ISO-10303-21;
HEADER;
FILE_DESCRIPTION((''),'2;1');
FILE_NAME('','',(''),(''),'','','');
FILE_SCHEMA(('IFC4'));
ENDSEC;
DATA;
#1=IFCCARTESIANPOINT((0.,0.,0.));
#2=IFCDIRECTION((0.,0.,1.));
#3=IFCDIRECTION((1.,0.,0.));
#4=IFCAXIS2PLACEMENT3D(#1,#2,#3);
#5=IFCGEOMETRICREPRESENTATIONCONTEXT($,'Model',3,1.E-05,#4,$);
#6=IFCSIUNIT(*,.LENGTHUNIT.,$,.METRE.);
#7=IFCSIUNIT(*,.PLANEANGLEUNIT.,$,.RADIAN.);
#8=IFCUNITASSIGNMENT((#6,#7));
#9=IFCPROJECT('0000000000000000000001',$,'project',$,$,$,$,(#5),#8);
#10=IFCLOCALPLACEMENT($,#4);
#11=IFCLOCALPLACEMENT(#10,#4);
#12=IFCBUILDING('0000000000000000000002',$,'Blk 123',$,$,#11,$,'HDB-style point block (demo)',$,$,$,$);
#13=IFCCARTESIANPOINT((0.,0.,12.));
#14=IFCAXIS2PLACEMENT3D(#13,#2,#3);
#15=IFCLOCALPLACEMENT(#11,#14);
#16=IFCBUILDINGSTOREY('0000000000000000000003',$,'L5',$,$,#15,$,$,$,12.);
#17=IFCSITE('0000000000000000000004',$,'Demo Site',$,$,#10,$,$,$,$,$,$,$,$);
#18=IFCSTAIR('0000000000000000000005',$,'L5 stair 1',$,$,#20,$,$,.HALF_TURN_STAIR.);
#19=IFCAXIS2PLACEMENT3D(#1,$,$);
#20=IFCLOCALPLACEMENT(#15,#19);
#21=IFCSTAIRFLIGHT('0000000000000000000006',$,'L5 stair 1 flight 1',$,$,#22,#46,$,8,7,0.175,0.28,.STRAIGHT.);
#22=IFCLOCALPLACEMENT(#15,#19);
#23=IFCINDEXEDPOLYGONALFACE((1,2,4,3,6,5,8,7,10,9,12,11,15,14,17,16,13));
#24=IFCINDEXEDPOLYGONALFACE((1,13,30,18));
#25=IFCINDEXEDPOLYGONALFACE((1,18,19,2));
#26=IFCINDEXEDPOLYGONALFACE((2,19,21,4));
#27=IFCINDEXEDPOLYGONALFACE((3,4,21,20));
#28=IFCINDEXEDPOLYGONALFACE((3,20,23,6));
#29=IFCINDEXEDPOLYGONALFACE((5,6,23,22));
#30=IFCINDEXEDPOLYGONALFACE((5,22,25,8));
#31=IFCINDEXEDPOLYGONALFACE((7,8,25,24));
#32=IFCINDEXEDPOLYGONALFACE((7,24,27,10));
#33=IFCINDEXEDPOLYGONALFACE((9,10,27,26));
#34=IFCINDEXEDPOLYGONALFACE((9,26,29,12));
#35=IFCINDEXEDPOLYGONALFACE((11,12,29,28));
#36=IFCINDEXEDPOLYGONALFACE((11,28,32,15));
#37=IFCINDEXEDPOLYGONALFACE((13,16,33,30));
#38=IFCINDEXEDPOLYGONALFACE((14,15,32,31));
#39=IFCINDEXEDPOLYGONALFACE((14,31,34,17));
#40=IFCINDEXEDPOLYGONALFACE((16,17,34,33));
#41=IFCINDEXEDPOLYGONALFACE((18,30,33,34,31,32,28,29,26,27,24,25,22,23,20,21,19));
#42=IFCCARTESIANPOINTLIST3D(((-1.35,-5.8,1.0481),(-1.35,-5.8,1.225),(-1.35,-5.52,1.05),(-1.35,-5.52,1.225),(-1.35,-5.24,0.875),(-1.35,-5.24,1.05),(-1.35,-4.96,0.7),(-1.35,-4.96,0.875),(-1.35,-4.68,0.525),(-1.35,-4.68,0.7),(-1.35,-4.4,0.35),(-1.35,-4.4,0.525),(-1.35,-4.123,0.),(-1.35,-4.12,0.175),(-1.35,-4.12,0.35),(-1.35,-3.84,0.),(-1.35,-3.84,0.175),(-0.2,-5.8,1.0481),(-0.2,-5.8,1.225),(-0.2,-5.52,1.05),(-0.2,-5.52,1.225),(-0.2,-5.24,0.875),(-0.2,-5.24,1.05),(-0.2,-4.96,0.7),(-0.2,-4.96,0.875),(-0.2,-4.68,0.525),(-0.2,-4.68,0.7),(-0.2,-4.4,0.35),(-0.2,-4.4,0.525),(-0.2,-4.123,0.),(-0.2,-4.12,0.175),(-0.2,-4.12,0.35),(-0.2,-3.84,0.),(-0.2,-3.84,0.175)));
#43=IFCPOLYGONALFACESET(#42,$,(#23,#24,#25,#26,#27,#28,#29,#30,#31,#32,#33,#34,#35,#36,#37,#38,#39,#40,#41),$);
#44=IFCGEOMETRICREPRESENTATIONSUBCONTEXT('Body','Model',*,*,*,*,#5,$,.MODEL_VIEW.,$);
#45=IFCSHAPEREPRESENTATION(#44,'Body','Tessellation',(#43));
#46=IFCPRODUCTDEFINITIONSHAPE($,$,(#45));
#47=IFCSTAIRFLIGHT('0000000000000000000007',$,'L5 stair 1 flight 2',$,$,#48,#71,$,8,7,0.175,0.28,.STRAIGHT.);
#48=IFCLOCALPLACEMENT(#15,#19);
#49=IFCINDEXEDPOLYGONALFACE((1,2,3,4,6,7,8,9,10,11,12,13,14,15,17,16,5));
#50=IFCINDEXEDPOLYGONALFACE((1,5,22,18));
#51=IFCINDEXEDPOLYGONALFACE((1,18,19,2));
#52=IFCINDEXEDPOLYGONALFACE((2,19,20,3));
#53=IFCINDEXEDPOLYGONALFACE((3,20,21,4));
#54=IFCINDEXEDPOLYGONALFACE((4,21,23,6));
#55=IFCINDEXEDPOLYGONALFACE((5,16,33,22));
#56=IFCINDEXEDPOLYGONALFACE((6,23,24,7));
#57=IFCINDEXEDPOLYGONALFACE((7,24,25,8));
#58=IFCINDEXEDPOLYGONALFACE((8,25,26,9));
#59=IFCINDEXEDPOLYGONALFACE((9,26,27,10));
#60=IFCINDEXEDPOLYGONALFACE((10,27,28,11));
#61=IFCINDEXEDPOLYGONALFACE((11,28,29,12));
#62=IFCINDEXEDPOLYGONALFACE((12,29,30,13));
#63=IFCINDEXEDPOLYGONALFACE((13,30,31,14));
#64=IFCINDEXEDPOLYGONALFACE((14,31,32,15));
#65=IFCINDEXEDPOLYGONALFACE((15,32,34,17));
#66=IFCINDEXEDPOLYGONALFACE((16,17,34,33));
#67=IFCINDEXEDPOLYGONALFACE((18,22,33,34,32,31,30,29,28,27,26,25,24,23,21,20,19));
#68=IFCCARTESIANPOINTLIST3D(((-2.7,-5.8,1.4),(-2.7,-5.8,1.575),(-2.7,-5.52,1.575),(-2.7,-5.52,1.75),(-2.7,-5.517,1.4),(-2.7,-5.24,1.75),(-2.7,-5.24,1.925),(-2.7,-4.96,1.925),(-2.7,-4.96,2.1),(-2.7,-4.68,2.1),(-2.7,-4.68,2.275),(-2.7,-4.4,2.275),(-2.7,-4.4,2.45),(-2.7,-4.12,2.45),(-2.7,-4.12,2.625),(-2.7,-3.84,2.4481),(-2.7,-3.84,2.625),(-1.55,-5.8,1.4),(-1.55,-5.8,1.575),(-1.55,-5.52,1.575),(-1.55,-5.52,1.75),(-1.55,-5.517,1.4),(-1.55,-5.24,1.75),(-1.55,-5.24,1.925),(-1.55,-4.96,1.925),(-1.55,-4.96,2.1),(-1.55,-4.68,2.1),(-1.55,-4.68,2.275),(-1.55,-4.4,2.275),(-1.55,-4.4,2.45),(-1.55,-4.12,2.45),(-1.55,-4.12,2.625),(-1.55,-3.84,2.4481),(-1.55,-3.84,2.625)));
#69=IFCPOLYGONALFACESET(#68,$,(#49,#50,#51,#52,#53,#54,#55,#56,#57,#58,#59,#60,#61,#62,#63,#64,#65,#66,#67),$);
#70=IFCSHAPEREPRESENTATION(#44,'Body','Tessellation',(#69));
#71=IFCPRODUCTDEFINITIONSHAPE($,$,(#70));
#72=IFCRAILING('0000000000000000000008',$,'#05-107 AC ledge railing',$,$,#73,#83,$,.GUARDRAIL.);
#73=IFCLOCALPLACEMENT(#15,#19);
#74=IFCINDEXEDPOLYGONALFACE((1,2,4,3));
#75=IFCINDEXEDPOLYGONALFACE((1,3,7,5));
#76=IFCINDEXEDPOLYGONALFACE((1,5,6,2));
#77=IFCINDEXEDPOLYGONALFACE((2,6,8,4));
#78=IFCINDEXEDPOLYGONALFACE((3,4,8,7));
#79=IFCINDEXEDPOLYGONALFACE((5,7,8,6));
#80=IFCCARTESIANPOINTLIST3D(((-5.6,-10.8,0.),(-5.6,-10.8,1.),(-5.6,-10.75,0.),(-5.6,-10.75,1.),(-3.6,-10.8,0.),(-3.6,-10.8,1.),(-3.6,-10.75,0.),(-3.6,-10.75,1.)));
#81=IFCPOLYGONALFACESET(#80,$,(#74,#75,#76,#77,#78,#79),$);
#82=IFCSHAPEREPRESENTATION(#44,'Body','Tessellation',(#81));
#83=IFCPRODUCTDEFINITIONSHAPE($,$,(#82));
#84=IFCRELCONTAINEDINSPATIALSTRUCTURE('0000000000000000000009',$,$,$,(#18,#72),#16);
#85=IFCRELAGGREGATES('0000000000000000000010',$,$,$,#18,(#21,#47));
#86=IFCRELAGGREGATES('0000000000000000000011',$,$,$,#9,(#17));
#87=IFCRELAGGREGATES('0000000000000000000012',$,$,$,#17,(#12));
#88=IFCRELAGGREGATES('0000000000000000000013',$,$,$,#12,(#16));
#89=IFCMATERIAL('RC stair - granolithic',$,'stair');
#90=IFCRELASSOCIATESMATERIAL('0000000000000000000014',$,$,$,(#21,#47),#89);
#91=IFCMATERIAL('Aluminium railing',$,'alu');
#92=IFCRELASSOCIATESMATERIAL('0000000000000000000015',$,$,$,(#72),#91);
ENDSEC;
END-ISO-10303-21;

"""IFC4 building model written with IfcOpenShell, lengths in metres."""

from ifc_helpers import new_model, si_unit, frame, origin, origin_with_axes, place, context, subcontext, project, spatial, polyline, outline, extrude, material, element, aggregate, save


model = new_model("IFC4")

# Units and contexts
model_context = context("Model", 3, precision=1e-05, world=origin_with_axes())
body_context = subcontext(model_context, "Body", "Model", "MODEL_VIEW")
ifc_project = project(units=[si_unit("LENGTHUNIT", "METRE"), si_unit("PLANEANGLEUNIT", "RADIAN")], contexts=[model_context])

# Site, building, storey
site_placement = place(None, origin_with_axes())
site = spatial("IfcSite", under=ifc_project, at=site_placement, Name="Demo Site")
building_placement = place(site_placement, origin_with_axes())
building = spatial("IfcBuilding", under=site, at=building_placement, Name="Blk 123", LongName="HDB-style point block (demo)")
storey_placement = place(building_placement, frame((0.0, 0.0, 12.0), z_axis=(0.0, 0.0, 1.0), x_axis=(1.0, 0.0, 0.0)))
storey = spatial("IfcBuildingStorey", under=building, at=storey_placement, Name="L5", Elevation=12.0)

# Stair
stair_placement = place(storey_placement, frame((-2.7, -7.1, 0.0), z_axis=(0.0, 0.0, 1.0), x_axis=(1.0, 0.0, 0.0)))
stair = element("IfcStair", 1, at=stair_placement, inside=storey, Name="L5 stair 1", PredefinedType="HALF_TURN_STAIR")
ifc_material_1 = material(Name="RC stair - granolithic", Category="stair")

# Stair flights
stair_flight_1_placement = place(stair_placement, frame((2.5, 3.26, 0.0), z_axis=(0.0, 0.0, 1.0), x_axis=(1.0, 0.0, 0.0)))
stair_flight_1 = element("IfcStairFlight", 2, at=stair_flight_1_placement, material=ifc_material_1, Name="L5 stair 1 flight 1", NumberOfRisers=8, NumberOfTreads=7, PredefinedType="STRAIGHT", RiserHeight=0.175, TreadLength=0.28, context=body_context, shape_type="SweptSolid", body=[
    extrude(outline(polyline([(0.0, 0.0), (0.0, 0.175), (0.28, 0.175), (0.28, 0.35), (0.56, 0.35), (0.56, 0.525), (0.84, 0.525), (0.84, 0.7), (1.12, 0.7), (1.12, 0.875), (1.4, 0.875), (1.4, 1.05), (1.68, 1.05), (1.68, 1.225), (1.96, 1.225), (1.96, 1.4), (1.96, 1.0481), (0.283, 0.0), (0.0, 0.0)])), frame((0.0, 0.0, 0.0), z_axis=(-1.0, 0.0, 0.0), x_axis=(0.0, -1.0, 0.0)), (0.0, 0.0, 1.0), 1.15),
])
stair_flight_2_placement = place(stair_placement, frame((0.0, 1.3, 1.4), z_axis=(0.0, 0.0, 1.0), x_axis=(1.0, 0.0, 0.0)))
stair_flight_2 = element("IfcStairFlight", 3, at=stair_flight_2_placement, material=ifc_material_1, Name="L5 stair 1 flight 2", NumberOfRisers=8, NumberOfTreads=7, PredefinedType="STRAIGHT", RiserHeight=0.175, TreadLength=0.28, context=body_context, shape_type="SweptSolid", body=[
    extrude(outline(polyline([(0.0, 0.0), (0.0, 0.175), (0.28, 0.175), (0.28, 0.35), (0.56, 0.35), (0.56, 0.525), (0.84, 0.525), (0.84, 0.7), (1.12, 0.7), (1.12, 0.875), (1.4, 0.875), (1.4, 1.05), (1.68, 1.05), (1.68, 1.225), (1.96, 1.225), (1.96, 1.4), (1.96, 1.0481), (0.283, 0.0), (0.0, 0.0)])), frame((0.0, 0.0, 0.0), z_axis=(1.0, 0.0, 0.0), x_axis=(0.0, 1.0, 0.0)), (0.0, 0.0, 1.0), 1.15),
])

# Railing
aggregate(stair, [stair_flight_1, stair_flight_2])
ifc_material_2 = material(Name="Aluminium railing", Category="alu")
railing_1_placement = place(storey_placement, frame((-4.6, -10.775, 0.0), z_axis=(0.0, 0.0, 1.0), x_axis=(1.0, 0.0, 0.0)))
element("IfcRailing", 4, at=railing_1_placement, inside=storey, material=ifc_material_2, Name="#05-107 AC ledge railing", PredefinedType="GUARDRAIL", context=body_context, shape_type="SweptSolid", body=[
    extrude(outline(polyline([(-1.0, 0.025), (-1.0, -0.025), (1.0, -0.025), (1.0, 0.025), (-1.0, 0.025)])), origin(), (0.0, 0.0, 1.0), 1.0),
])

save(model, "model.ifc")
